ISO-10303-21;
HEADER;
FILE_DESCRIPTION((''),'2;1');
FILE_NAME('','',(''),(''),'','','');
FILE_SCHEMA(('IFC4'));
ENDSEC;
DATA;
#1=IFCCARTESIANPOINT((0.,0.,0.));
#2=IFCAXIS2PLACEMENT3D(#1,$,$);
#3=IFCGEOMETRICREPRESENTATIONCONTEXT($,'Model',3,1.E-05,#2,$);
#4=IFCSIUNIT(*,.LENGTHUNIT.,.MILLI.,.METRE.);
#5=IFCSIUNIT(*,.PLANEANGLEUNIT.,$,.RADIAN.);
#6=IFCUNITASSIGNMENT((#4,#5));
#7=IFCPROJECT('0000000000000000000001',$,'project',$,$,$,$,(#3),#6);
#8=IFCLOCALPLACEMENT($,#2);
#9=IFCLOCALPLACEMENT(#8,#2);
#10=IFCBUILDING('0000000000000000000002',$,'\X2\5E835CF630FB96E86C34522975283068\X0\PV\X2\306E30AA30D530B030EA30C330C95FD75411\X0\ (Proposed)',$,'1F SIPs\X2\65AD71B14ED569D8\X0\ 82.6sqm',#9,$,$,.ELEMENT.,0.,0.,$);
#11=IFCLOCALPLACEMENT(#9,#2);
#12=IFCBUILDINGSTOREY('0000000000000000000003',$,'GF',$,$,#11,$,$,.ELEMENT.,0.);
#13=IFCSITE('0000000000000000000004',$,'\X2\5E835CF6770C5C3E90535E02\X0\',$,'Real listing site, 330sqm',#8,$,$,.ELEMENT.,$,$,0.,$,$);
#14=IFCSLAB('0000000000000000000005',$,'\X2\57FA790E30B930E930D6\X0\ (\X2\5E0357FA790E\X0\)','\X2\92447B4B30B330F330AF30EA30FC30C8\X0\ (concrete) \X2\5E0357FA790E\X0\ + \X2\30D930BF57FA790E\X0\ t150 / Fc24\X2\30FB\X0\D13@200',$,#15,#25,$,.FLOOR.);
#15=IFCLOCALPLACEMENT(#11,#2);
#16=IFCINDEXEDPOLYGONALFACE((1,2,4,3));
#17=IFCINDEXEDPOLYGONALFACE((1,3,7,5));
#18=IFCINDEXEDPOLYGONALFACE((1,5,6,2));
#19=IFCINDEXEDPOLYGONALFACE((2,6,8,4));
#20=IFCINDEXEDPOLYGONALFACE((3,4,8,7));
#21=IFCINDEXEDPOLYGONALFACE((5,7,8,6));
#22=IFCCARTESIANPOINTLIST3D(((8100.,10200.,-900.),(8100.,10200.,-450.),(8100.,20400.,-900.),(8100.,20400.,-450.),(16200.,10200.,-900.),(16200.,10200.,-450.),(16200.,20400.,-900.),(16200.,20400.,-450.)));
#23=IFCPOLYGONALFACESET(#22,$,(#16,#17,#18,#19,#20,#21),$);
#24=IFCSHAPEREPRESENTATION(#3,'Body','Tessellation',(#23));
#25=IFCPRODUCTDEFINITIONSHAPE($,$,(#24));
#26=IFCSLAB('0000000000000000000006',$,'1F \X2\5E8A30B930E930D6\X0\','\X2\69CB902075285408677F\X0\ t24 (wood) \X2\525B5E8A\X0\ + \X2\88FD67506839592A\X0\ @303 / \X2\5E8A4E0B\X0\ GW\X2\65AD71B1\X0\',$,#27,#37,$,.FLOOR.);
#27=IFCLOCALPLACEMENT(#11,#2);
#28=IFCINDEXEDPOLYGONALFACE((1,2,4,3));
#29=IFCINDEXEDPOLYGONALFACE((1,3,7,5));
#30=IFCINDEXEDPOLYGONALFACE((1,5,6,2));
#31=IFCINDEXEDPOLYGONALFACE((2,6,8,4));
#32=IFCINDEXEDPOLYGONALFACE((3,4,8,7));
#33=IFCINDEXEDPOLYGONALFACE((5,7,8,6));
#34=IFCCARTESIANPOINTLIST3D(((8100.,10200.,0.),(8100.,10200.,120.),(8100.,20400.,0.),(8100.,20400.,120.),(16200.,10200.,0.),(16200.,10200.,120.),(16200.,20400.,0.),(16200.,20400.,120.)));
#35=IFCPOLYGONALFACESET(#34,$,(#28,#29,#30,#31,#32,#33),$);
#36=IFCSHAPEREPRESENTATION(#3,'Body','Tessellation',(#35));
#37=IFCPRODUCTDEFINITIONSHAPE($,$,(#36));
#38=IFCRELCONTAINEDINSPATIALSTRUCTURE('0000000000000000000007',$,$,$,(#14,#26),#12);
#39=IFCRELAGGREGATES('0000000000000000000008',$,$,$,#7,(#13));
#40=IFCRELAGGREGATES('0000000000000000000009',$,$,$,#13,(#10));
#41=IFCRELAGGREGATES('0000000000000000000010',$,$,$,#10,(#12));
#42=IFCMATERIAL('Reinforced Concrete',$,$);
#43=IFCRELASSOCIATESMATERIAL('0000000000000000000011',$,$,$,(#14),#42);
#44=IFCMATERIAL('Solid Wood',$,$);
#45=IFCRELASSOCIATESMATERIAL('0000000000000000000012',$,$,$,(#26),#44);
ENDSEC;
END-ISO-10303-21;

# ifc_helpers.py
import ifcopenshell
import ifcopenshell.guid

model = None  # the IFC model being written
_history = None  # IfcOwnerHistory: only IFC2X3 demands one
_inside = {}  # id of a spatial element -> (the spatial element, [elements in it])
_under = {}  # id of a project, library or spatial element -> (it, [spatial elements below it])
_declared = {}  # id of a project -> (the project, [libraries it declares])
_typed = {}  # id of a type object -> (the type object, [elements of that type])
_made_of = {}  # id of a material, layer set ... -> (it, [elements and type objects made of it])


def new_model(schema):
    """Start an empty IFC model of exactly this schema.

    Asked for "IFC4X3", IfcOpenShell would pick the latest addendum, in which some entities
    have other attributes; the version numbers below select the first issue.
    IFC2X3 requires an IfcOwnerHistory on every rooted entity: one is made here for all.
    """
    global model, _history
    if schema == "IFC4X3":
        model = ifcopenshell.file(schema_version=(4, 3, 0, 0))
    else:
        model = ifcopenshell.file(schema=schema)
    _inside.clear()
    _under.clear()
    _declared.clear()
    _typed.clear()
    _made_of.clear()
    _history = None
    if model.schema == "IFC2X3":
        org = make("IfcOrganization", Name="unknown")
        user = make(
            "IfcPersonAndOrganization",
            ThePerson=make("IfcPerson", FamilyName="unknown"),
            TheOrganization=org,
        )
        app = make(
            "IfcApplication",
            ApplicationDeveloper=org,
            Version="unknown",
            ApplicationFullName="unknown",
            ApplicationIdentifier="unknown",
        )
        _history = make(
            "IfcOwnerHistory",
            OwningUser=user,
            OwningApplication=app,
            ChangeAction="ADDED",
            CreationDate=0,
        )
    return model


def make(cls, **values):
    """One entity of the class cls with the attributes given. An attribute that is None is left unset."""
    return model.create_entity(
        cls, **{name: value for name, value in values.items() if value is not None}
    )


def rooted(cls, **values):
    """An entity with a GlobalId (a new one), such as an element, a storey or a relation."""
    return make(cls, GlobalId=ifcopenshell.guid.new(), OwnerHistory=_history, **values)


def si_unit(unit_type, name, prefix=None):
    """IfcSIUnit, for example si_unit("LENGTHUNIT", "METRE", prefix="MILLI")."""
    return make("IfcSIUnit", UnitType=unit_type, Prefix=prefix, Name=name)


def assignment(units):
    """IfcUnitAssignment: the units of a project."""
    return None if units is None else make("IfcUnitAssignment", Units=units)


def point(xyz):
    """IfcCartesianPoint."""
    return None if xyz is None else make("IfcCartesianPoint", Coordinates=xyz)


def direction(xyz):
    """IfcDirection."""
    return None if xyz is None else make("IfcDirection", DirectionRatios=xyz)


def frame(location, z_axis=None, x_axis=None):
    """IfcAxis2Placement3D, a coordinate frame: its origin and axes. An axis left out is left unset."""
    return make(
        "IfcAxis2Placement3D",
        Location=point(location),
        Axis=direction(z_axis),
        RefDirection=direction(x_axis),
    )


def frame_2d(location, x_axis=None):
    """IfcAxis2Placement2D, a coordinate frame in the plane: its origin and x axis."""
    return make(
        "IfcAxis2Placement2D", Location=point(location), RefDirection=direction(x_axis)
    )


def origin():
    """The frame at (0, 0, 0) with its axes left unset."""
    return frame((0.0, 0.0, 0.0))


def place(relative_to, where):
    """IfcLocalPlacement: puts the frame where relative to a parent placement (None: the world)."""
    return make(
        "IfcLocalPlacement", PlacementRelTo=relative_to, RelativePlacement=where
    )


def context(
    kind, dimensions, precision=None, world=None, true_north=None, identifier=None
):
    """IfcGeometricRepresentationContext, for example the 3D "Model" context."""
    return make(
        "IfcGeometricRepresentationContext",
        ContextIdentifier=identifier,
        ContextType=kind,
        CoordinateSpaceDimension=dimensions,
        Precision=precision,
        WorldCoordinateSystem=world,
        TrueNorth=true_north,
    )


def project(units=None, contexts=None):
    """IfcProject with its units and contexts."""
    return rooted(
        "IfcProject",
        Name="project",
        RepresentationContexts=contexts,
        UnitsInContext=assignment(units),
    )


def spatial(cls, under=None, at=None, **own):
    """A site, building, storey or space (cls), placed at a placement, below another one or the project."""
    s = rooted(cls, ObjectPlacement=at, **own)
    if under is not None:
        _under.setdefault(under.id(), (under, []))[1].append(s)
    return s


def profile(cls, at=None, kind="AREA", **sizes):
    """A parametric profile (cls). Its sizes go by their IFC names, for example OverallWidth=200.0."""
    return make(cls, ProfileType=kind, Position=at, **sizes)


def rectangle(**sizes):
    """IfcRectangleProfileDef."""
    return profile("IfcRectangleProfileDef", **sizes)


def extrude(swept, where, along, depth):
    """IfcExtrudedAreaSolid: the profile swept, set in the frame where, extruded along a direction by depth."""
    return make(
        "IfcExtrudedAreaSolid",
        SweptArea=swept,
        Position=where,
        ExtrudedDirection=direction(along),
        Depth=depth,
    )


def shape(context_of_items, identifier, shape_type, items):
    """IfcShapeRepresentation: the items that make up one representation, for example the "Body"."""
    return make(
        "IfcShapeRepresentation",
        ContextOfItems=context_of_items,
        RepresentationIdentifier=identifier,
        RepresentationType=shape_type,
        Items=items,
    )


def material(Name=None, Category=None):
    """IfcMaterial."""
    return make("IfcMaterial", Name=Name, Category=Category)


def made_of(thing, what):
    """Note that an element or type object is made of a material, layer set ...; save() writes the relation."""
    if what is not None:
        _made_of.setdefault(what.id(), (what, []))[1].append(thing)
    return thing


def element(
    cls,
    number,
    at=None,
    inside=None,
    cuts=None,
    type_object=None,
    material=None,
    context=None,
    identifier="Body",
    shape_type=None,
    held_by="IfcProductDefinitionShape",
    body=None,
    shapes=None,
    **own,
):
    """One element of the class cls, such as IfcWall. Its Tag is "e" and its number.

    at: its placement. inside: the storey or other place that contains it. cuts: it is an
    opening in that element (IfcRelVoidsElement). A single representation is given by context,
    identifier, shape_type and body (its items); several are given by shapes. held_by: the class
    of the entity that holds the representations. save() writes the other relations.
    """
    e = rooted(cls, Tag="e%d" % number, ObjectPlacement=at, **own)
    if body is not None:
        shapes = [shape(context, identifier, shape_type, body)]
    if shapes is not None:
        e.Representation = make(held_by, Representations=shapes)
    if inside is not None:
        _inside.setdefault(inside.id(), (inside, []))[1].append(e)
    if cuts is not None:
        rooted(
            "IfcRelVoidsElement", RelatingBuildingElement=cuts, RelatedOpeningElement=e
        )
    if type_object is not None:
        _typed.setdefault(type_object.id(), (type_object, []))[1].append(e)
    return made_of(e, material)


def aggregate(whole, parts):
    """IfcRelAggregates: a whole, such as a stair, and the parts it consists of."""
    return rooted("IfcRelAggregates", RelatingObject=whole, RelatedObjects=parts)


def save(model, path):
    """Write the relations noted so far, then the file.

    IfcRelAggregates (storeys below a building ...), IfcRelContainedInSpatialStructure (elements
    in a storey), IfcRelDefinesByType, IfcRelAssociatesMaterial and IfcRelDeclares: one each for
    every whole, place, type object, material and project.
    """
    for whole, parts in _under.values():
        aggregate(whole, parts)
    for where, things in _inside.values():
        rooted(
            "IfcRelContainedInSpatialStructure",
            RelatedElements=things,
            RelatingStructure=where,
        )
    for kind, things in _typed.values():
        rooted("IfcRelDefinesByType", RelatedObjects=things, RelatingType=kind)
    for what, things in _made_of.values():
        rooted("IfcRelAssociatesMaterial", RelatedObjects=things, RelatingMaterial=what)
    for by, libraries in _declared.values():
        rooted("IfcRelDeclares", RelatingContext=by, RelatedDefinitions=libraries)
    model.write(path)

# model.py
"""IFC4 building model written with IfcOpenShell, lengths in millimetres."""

from ifc_helpers import new_model, si_unit, frame, frame_2d, origin, place, context, project, spatial, rectangle, extrude, material, element, save


model = new_model("IFC4")

# Units and contexts
model_context = context("Model", 3, precision=1e-05, world=origin())
ifc_project = project(units=[si_unit("LENGTHUNIT", "METRE", prefix="MILLI"), si_unit("PLANEANGLEUNIT", "RADIAN")], contexts=[model_context])

# Site, building, storey
site_placement = place(None, origin())
site = spatial("IfcSite", under=ifc_project, at=site_placement, Name="広島県尾道市", ObjectType="Real listing site, 330sqm", CompositionType="ELEMENT", RefElevation=0.0)
building_placement = place(site_placement, origin())
building = spatial("IfcBuilding", under=site, at=building_placement, Name="広島・雨水利用とPVのオフグリッド志向 (Proposed)", ObjectType="1F SIPs断熱仕様 82.6sqm", CompositionType="ELEMENT", ElevationOfRefHeight=0.0, ElevationOfTerrain=0.0)
storey_placement = place(building_placement, origin())
storey = spatial("IfcBuildingStorey", under=building, at=storey_placement, Name="GF", CompositionType="ELEMENT", Elevation=0.0)

# Shared definitions
ifc_material_1 = material(Name="Solid Wood")

# Slabs
ifc_material_2 = material(Name="Reinforced Concrete")
slab_1_placement = place(storey_placement, frame((4050.0, 5100.0, -450.0)))
element("IfcSlab", 1, at=slab_1_placement, inside=storey, material=ifc_material_2, Name="基礎スラブ (布基礎)", Description="鉄筋コンクリート (concrete) 布基礎 + ベタ基礎 t150 / Fc24・D13@200", PredefinedType="FLOOR", context=model_context, shape_type="SweptSolid", body=[
    extrude(rectangle(XDim=8100.0, YDim=10200.0, at=frame_2d((4050.0, 5100.0))), frame((4050.0, 5100.0, -450.0)), (0.0, 0.0, 1.0), 450.0),
])
slab_2_placement = place(storey_placement, frame((4050.0, 5100.0, 0.0)))
element("IfcSlab", 2, at=slab_2_placement, inside=storey, material=ifc_material_1, Name="1F 床スラブ", Description="構造用合板 t24 (wood) 剛床 + 製材根太 @303 / 床下 GW断熱", PredefinedType="FLOOR", context=model_context, shape_type="SweptSolid", body=[
    extrude(rectangle(XDim=8100.0, YDim=10200.0, at=frame_2d((4050.0, 5100.0))), frame((4050.0, 5100.0, 0.0)), (0.0, 0.0, 1.0), 120.0),
])

save(model, "model.ifc")
